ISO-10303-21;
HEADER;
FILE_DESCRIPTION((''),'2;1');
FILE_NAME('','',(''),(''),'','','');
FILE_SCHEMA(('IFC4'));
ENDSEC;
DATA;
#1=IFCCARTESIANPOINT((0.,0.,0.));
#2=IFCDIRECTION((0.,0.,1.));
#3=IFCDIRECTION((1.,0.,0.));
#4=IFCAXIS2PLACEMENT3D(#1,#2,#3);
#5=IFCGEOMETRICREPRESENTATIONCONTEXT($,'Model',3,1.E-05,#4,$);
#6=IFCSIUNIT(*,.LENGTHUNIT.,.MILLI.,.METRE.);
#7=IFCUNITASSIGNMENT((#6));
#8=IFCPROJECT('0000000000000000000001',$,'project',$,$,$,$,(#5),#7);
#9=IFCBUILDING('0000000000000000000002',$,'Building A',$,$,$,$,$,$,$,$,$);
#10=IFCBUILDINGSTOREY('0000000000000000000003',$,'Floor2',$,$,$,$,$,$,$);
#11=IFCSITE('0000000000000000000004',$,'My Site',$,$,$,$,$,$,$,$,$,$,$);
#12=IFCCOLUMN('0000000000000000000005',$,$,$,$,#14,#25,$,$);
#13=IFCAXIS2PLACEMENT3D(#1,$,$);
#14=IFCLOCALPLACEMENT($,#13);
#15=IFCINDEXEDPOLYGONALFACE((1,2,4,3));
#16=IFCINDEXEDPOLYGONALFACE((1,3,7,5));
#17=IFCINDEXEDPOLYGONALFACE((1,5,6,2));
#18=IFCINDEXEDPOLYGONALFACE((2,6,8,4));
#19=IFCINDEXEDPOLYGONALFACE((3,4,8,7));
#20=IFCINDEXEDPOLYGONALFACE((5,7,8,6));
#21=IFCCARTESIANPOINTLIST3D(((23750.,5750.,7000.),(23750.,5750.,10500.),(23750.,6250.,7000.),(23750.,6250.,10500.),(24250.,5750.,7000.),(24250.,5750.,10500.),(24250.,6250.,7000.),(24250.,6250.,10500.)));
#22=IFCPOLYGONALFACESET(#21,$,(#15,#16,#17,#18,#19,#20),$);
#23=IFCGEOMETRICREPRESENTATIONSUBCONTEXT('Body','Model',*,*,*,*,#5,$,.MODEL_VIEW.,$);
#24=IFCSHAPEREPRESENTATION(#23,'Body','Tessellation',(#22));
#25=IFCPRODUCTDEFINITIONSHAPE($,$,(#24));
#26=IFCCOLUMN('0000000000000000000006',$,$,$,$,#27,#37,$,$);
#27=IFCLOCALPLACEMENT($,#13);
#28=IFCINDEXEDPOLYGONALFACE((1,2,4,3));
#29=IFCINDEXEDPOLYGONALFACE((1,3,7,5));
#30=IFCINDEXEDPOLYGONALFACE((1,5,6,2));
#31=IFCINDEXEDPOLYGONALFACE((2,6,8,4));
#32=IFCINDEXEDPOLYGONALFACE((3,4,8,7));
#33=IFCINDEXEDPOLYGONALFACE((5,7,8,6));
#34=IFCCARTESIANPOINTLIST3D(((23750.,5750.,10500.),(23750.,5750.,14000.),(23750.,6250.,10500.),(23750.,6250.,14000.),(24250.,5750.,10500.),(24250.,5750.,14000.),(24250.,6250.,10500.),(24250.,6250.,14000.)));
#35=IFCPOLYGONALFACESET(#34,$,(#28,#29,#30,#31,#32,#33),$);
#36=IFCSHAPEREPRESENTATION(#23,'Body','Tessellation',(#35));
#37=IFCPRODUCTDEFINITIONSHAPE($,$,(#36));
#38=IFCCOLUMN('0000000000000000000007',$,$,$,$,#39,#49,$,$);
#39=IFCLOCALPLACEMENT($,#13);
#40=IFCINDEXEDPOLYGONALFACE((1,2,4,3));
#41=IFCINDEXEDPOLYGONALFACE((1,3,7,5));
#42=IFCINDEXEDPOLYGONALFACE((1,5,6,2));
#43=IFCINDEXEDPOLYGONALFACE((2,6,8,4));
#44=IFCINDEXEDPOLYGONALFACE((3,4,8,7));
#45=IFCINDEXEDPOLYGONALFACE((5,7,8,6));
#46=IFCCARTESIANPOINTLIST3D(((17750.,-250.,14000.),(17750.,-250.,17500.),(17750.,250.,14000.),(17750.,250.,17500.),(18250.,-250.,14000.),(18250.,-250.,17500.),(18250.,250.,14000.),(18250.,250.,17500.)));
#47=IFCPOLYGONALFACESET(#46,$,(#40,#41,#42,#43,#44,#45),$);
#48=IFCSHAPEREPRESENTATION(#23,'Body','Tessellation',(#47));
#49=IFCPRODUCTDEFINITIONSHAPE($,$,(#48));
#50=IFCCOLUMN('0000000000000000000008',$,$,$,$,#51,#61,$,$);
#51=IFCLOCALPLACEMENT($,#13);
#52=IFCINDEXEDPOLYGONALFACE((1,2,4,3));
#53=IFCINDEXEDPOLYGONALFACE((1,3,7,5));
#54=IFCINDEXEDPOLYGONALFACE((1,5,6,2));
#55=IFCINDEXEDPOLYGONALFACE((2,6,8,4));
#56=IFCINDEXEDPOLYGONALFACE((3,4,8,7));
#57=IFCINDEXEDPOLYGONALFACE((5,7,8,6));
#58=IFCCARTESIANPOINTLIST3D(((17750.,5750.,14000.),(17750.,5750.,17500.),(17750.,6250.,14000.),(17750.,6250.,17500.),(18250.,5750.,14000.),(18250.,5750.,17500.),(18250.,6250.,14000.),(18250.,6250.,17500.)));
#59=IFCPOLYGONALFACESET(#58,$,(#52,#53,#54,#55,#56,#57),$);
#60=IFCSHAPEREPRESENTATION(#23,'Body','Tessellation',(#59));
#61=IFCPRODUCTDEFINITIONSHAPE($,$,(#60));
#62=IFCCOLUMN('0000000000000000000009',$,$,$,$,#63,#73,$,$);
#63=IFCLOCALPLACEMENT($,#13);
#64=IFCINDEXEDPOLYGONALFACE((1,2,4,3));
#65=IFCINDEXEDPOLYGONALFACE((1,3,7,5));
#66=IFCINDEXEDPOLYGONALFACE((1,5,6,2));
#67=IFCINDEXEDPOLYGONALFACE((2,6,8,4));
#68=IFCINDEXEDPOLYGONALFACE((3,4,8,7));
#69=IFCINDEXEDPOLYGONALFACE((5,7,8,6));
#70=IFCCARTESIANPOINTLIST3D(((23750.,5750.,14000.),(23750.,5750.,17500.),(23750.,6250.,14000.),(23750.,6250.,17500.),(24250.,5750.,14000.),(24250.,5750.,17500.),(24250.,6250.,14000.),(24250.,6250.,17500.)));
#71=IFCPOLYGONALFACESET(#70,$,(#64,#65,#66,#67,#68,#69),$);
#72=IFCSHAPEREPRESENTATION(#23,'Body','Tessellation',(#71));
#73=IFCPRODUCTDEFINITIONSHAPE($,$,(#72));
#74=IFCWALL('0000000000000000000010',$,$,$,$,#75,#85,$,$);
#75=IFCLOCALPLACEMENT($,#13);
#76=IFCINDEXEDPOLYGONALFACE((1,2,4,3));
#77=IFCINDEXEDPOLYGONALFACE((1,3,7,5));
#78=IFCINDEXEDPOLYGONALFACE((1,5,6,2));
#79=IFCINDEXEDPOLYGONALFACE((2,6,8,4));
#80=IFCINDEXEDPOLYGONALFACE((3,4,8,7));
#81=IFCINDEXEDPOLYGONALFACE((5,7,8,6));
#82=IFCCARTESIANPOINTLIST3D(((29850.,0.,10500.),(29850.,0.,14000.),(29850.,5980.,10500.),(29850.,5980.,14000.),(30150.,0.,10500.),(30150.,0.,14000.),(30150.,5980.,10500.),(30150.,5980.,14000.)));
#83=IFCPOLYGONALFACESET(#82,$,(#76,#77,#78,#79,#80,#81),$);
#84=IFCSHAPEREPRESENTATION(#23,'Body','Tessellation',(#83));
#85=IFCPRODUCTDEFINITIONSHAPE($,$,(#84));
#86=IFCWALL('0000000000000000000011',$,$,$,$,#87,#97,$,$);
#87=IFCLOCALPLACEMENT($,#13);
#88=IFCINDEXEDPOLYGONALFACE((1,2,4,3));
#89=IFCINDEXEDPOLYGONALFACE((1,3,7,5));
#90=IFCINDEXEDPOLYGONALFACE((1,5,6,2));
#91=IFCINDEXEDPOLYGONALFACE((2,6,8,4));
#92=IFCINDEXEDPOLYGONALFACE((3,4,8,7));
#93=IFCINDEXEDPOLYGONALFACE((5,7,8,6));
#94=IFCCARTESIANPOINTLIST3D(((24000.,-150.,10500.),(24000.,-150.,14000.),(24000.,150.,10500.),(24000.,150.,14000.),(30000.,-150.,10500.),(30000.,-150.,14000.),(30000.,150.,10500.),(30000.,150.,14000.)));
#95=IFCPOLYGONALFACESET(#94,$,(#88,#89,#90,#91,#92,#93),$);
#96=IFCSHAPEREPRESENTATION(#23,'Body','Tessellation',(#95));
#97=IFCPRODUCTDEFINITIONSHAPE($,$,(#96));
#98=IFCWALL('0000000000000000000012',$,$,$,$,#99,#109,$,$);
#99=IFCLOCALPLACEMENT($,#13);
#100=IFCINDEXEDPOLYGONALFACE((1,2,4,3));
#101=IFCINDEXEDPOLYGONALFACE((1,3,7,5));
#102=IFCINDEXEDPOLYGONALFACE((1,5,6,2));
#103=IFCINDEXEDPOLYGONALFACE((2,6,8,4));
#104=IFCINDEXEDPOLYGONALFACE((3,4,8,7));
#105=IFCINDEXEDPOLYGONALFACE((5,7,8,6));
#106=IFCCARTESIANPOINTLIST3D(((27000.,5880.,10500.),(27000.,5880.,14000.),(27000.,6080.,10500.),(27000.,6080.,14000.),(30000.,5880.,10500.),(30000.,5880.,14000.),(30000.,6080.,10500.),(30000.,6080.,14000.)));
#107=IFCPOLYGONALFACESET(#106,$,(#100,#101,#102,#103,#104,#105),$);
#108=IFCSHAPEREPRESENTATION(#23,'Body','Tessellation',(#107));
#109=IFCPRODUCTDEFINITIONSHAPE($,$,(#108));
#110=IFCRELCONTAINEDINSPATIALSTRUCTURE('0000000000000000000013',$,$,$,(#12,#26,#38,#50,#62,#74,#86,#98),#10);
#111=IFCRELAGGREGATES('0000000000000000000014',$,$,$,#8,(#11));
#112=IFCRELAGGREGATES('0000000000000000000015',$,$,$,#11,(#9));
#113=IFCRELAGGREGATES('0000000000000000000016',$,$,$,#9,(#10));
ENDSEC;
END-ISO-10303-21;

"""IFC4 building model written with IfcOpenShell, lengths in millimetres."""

from ifc_helpers import new_model, si_unit, frame, origin_with_axes, place, context, subcontext, project, spatial, line, indexed_curve, outline, extrude, element, save


model = new_model("IFC4")

# Units and contexts
model_context = context("Model", 3, precision=1e-05, world=origin_with_axes())
body_context = subcontext(model_context, "Body", "Model", "MODEL_VIEW")
ifc_project = project(units=[si_unit("LENGTHUNIT", "METRE", prefix="MILLI")], contexts=[model_context])

# Site, building, storey
site = spatial("IfcSite", under=ifc_project, Name="My Site")
building = spatial("IfcBuilding", under=site, Name="Building A")
storey = spatial("IfcBuildingStorey", under=building, Name="Floor2")

# Columns
for number, where, z_axis, x_axis in (
    (1, (24000.0, 6000.0, 7000.0), (0.0, 0.0, 1.0), (1.0, 0.0, 0.0)),
    (2, (24000.0, 6000.0, 10500.0), (0.0, 0.0, 1.0), (1.0, 0.0, 0.0)),
    (3, (18000.0, 0.0, 14000.0), (0.0, 0.0, 1.0), (1.0, 0.0, 0.0)),
    (4, (18000.0, 6000.0, 14000.0), (0.0, 0.0, 1.0), (1.0, 0.0, 0.0)),
    (5, (24000.0, 6000.0, 14000.0), (0.0, 0.0, 1.0), (1.0, 0.0, 0.0)),
):
    element("IfcColumn", number, at=place(None, frame(where, z_axis=z_axis, x_axis=x_axis)), inside=storey, context=body_context, shape_type="SweptSolid", body=[
        extrude(outline(indexed_curve([(-250.0, -250.0), (250.0, -250.0), (250.0, 250.0), (-250.0, 250.0)], segments=[line(1, 2, 3, 4, 1)])), origin_with_axes(), (0.0, 0.0, 1.0), 3500.0),
    ])

# Walls
wall_1_placement = place(None, frame((29850.0, 5980.0, 10500.0), z_axis=(0.0, 0.0, 1.0), x_axis=(0.0, -1.0, 0.0)))
element("IfcWall", 6, at=wall_1_placement, inside=storey, context=body_context, shape_type="SweptSolid", body=[
    extrude(outline(indexed_curve([(0.0, 0.0), (0.0, 300.0), (5980.0, 300.0), (5980.0, 0.0), (0.0, 0.0)], self_intersect=False)), origin_with_axes(), (0.0, 0.0, 1.0), 3500.0),
])
wall_2_placement = place(None, frame((30000.0, 150.0, 10500.0), z_axis=(0.0, 0.0, 1.0), x_axis=(-1.0, 0.0, 0.0)))
element("IfcWall", 7, at=wall_2_placement, inside=storey, context=body_context, shape_type="SweptSolid", body=[
    extrude(outline(indexed_curve([(0.0, 0.0), (0.0, 300.0), (6000.0, 300.0), (6000.0, 0.0), (0.0, 0.0)], self_intersect=False)), origin_with_axes(), (0.0, 0.0, 1.0), 3500.0),
])
wall_3_placement = place(None, frame((27000.0, 5880.0, 10500.0), z_axis=(0.0, 0.0, 1.0), x_axis=(1.0, 0.0, 0.0)))
element("IfcWall", 8, at=wall_3_placement, inside=storey, context=body_context, shape_type="SweptSolid", body=[
    extrude(outline(indexed_curve([(0.0, 0.0), (0.0, 200.0), (3000.0, 200.0), (3000.0, 0.0), (0.0, 0.0)], self_intersect=False)), origin_with_axes(), (0.0, 0.0, 1.0), 3500.0),
])

save(model, "model.ifc")
